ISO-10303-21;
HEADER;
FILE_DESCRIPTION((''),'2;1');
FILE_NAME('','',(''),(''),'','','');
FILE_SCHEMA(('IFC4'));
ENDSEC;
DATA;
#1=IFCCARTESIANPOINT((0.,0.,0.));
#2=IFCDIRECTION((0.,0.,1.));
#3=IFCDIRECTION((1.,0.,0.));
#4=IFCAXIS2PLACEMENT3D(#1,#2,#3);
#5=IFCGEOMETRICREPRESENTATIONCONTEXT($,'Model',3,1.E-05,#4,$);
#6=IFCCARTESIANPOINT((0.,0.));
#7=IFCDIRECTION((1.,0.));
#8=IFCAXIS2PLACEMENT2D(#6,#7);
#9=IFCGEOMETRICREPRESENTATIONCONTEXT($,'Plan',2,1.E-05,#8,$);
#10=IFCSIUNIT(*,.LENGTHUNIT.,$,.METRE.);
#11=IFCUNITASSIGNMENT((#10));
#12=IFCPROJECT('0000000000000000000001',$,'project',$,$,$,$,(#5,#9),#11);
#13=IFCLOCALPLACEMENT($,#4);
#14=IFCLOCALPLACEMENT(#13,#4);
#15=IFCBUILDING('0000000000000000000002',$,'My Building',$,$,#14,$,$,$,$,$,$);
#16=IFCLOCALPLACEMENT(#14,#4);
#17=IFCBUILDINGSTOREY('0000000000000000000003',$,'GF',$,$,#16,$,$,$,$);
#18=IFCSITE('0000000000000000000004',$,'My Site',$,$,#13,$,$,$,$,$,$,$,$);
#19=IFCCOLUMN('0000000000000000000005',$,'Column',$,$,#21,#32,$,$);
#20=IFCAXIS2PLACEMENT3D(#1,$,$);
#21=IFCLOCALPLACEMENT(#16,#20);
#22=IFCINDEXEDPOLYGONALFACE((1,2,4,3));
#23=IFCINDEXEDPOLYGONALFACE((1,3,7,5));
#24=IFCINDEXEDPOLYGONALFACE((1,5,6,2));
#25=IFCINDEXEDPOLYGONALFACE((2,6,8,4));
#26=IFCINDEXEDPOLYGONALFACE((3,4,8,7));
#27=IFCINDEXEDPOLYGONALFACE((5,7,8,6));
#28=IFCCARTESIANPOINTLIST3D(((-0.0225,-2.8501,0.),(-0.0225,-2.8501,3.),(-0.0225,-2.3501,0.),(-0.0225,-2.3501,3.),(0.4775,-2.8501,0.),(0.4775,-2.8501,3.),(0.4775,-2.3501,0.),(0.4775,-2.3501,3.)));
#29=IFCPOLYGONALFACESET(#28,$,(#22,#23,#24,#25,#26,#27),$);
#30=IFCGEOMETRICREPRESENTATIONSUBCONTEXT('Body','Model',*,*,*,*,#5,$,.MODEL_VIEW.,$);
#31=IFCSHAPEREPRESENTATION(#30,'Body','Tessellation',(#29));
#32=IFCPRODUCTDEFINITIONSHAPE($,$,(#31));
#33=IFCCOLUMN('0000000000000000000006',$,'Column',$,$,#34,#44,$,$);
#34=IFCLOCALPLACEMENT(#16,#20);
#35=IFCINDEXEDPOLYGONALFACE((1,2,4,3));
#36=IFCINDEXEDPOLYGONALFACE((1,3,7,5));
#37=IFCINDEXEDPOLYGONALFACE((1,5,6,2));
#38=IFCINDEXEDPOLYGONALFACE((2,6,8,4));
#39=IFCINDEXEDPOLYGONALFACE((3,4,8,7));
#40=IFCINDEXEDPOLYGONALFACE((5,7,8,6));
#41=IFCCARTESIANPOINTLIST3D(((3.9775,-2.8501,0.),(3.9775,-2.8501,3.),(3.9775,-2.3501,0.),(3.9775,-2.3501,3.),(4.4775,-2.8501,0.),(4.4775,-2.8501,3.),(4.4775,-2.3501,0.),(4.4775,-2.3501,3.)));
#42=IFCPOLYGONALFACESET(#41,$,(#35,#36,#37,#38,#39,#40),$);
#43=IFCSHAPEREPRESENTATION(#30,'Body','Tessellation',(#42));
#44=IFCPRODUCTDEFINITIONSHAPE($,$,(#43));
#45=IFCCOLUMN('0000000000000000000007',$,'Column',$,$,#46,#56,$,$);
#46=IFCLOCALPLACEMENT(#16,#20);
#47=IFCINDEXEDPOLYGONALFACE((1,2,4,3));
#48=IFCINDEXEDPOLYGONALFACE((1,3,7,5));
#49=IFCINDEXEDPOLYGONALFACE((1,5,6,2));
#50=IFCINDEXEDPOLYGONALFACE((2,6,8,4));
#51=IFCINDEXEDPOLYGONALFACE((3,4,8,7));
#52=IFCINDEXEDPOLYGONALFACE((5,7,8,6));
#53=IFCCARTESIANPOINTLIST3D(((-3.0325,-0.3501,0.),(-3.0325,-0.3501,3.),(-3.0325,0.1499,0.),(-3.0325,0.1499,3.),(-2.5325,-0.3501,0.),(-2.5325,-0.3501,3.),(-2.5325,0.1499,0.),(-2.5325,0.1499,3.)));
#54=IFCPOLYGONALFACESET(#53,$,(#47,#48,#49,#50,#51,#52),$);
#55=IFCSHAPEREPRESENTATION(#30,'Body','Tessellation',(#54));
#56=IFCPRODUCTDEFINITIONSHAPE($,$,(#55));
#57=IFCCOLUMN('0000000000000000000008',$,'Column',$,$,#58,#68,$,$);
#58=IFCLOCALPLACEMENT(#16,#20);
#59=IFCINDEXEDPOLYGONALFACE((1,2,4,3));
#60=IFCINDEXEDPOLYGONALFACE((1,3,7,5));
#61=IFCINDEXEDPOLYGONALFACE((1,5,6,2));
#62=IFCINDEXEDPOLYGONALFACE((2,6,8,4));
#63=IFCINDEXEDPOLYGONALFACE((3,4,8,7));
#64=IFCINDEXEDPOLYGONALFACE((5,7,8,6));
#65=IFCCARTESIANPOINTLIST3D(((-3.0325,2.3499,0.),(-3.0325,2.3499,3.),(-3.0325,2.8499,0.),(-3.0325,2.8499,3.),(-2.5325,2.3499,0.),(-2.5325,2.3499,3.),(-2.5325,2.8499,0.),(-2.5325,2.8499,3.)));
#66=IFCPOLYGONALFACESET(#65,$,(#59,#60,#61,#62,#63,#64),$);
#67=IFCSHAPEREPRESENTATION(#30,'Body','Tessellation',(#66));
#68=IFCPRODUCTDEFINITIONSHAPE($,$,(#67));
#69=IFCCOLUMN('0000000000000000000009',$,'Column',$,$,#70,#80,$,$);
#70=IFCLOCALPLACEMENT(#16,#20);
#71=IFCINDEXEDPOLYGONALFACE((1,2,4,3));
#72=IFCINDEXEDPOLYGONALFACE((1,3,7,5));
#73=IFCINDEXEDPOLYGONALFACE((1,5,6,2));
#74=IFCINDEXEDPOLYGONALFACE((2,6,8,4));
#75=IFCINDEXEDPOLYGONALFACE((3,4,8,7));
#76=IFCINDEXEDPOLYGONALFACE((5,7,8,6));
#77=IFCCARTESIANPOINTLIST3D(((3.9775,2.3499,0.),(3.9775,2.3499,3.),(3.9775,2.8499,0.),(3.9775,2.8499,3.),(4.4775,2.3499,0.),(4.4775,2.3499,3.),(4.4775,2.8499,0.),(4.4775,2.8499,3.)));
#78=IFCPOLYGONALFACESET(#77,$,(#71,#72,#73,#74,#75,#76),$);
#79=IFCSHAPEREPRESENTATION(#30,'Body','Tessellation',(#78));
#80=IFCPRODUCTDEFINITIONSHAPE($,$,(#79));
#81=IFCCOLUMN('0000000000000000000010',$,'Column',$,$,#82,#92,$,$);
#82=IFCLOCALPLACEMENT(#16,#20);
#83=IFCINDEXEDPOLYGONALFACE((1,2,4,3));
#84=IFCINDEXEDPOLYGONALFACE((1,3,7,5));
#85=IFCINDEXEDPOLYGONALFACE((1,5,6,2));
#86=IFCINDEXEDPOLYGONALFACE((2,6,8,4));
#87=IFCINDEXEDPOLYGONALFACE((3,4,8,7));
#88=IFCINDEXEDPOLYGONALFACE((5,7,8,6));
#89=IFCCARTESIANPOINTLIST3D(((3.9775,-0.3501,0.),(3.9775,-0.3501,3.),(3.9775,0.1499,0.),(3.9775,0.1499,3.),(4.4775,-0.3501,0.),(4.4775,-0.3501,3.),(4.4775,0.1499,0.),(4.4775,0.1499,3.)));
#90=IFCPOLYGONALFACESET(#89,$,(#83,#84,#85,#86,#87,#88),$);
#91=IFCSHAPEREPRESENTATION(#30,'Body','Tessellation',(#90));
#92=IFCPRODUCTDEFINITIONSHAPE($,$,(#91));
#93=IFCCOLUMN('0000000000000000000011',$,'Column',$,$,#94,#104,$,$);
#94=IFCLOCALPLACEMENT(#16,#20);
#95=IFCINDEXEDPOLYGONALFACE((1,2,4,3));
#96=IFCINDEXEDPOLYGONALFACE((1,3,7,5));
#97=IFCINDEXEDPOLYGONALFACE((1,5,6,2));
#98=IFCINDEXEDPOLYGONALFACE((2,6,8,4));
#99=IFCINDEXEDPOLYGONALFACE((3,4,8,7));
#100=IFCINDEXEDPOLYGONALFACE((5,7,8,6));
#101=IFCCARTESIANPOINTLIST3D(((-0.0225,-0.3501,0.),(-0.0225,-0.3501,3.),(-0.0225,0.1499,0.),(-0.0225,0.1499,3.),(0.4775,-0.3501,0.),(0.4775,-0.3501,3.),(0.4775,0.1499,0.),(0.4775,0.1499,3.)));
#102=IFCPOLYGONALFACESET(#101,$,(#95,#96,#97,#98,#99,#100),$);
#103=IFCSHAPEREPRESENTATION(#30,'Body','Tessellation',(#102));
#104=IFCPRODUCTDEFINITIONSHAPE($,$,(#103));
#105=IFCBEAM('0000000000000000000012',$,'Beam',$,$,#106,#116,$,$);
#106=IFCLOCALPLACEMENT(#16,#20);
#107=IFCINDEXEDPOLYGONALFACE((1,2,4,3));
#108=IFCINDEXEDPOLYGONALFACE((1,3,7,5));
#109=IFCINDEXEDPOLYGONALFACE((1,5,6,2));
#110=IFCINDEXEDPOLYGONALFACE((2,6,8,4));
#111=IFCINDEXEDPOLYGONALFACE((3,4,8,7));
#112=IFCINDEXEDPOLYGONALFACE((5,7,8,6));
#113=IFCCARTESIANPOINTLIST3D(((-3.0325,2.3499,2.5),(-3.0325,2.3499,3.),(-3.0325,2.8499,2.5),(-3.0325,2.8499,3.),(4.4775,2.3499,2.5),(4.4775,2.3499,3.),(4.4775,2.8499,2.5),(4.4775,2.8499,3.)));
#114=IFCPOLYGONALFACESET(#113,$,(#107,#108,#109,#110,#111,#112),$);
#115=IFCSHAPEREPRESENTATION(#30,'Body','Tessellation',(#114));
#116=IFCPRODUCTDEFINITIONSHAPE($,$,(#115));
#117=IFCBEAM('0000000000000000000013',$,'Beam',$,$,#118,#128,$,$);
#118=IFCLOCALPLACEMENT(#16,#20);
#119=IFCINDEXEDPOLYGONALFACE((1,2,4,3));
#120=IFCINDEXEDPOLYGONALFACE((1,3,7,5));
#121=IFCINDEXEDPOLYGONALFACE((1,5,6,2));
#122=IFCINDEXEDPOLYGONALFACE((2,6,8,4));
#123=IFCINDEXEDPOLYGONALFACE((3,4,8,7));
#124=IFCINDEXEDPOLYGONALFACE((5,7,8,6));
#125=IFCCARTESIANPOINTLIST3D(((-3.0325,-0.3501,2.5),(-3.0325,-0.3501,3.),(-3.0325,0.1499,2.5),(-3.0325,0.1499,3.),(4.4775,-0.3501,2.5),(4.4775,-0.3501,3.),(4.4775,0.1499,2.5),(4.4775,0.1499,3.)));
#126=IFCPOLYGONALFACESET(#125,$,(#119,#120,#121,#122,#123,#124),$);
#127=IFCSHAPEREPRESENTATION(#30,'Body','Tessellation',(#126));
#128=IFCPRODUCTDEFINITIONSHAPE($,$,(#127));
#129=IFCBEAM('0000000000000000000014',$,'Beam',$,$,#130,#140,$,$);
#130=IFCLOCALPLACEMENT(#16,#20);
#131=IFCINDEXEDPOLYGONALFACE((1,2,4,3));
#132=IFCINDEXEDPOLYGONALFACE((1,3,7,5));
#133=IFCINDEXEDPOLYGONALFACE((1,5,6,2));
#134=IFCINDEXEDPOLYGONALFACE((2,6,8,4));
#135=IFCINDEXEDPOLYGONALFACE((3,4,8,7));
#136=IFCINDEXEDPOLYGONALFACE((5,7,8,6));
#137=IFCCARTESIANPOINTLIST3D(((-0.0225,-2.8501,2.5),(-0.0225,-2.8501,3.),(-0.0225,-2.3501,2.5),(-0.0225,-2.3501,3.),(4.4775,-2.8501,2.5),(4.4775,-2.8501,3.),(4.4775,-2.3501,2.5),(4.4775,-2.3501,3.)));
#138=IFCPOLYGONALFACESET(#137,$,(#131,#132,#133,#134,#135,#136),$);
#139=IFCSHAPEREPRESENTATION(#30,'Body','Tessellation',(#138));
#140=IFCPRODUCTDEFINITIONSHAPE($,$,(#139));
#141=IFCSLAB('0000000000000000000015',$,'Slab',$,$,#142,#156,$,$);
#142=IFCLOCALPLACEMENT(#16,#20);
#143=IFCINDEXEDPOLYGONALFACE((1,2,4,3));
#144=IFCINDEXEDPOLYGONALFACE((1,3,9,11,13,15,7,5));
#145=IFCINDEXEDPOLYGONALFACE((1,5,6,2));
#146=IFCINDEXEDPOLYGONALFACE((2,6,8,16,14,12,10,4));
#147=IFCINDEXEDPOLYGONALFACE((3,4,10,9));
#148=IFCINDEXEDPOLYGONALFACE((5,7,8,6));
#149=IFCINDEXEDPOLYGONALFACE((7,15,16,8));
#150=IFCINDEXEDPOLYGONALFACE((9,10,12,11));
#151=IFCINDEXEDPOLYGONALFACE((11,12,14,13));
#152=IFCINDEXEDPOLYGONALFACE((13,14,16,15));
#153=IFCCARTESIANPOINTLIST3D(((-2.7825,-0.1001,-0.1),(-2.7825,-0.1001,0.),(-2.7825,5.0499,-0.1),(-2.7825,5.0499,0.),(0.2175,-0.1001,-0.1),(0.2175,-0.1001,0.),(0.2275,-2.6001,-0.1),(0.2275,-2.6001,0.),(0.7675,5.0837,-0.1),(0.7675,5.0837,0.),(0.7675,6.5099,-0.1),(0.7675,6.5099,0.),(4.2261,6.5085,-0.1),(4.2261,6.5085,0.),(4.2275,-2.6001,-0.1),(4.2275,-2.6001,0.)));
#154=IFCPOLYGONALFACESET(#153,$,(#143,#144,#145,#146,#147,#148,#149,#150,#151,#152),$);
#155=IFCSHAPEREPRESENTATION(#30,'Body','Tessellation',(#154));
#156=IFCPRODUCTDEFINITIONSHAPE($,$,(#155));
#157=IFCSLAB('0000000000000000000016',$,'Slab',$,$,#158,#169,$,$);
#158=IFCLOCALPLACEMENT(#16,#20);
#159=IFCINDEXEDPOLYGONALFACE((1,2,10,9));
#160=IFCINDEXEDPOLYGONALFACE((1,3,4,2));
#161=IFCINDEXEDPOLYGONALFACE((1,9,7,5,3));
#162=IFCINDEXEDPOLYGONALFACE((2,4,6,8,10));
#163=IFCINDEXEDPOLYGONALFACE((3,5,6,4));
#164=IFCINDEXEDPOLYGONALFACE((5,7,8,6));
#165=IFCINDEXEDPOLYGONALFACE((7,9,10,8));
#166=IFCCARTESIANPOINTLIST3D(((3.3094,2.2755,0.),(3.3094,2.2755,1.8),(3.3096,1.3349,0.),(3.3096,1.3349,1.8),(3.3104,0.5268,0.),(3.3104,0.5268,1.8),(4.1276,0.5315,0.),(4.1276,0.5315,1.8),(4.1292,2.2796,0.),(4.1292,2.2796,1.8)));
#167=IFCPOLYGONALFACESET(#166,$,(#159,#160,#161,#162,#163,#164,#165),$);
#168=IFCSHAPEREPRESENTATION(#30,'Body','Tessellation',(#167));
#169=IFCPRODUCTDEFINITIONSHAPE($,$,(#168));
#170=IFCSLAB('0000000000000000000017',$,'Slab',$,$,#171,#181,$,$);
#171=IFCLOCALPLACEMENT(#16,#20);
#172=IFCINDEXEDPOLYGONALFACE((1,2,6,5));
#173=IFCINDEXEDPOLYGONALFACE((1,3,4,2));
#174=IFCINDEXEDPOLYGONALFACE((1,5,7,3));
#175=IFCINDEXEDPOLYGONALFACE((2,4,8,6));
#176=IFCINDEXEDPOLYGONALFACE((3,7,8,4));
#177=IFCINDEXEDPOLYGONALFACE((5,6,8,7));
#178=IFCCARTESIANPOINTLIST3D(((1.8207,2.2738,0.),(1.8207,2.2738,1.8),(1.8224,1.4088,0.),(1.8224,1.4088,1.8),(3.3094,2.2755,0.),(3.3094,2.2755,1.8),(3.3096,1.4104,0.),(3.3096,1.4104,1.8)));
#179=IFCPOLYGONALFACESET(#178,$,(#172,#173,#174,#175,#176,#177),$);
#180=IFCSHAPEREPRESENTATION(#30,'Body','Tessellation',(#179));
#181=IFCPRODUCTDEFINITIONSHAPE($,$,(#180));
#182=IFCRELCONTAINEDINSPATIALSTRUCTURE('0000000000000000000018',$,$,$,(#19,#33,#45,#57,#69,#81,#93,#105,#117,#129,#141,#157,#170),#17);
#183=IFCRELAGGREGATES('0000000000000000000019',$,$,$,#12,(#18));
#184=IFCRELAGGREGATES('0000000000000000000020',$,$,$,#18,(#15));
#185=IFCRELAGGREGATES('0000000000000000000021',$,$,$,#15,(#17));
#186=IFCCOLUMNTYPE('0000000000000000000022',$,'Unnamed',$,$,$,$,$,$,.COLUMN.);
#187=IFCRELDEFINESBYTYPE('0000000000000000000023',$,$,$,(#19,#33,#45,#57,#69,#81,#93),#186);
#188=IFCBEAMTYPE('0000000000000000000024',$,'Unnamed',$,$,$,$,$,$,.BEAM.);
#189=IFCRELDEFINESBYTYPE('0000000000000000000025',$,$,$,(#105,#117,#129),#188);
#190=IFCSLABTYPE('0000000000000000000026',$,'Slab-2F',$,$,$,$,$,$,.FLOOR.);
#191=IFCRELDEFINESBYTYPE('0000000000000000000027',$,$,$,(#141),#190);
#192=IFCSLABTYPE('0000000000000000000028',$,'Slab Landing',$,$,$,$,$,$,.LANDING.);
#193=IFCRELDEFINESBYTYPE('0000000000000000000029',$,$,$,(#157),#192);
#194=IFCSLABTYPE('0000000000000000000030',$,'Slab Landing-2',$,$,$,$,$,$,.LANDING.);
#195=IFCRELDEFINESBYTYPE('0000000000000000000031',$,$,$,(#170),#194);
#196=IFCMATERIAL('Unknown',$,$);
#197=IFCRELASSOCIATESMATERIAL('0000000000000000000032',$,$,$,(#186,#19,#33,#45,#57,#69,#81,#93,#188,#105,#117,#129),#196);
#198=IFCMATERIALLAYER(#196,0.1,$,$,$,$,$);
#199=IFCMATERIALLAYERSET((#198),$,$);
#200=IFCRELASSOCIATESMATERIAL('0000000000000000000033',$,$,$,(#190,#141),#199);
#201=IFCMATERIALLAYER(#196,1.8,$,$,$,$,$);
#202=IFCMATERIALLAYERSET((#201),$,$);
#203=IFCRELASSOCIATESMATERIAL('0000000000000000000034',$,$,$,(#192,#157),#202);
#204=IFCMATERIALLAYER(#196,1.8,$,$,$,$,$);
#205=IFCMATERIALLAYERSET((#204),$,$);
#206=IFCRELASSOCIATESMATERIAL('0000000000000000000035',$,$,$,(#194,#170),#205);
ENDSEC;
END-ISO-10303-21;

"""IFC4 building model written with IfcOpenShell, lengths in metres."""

from ifc_helpers import new_model, si_unit, frame, origin_with_axes, origin_2d_with_axis, place, context, subcontext, project, spatial, indexed_curve, rectangle, outline, extrude, material, layer, layer_set, layer_usage, material_profile, profile_set, profile_usage, type_object, element, save


model = new_model("IFC4")

# Units and contexts
model_context = context("Model", 3, precision=1e-05, world=origin_with_axes())
plan_context = context("Plan", 2, precision=1e-05, world=origin_2d_with_axis())
body_context_1 = subcontext(model_context, "Body", "Model", "MODEL_VIEW")
ifc_project = project(units=[si_unit("LENGTHUNIT", "METRE")], contexts=[model_context, plan_context])

# Site, building, storey
site_placement = place(None, origin_with_axes())
site = spatial("IfcSite", under=ifc_project, at=site_placement, Name="My Site")
building_placement = place(site_placement, origin_with_axes())
building = spatial("IfcBuilding", under=site, at=building_placement, Name="My Building")
storey_placement = place(building_placement, origin_with_axes())
storey = spatial("IfcBuildingStorey", under=building, at=storey_placement, Name="GF")

# Columns
ifc_material = material(Name="Unknown")
ifc_material_profile_1 = material_profile(ifc_material, rectangle(XDim=0.5, YDim=0.5))
ifc_profile_set_1 = profile_set([ifc_material_profile_1])
ifc_profile_usage_1 = profile_usage(ifc_profile_set_1, cardinal=5)
column_type = type_object("IfcColumnType", Name="Unnamed", PredefinedType="COLUMN", material=ifc_profile_set_1)
column_1_placement = place(storey_placement, frame((0.2275, -2.6001, 0.0), z_axis=(0.0, 0.0, 1.0), x_axis=(1.0, 0.0, 0.0)))
element("IfcColumn", 1, at=column_1_placement, inside=storey, type_object=column_type, material=ifc_profile_usage_1, Name="Column", context=body_context_1, shape_type="SweptSolid", body=[
    extrude(rectangle(XDim=0.5, YDim=0.5), origin_with_axes(), (0.0, 0.0, 1.0), 3.0),
])
ifc_profile_usage_2 = profile_usage(ifc_profile_set_1, cardinal=5)
column_2_placement = place(storey_placement, frame((4.2275, -2.6001, 0.0), z_axis=(0.0, 0.0, 1.0), x_axis=(1.0, 0.0, 0.0)))
element("IfcColumn", 2, at=column_2_placement, inside=storey, type_object=column_type, material=ifc_profile_usage_2, Name="Column", context=body_context_1, shape_type="SweptSolid", body=[
    extrude(rectangle(XDim=0.5, YDim=0.5), origin_with_axes(), (0.0, 0.0, 1.0), 3.0),
])
ifc_profile_usage_3 = profile_usage(ifc_profile_set_1, cardinal=5)
column_3_placement = place(storey_placement, frame((-2.7825, -0.1001, 0.0), z_axis=(0.0, 0.0, 1.0), x_axis=(1.0, 0.0, 0.0)))
element("IfcColumn", 3, at=column_3_placement, inside=storey, type_object=column_type, material=ifc_profile_usage_3, Name="Column", context=body_context_1, shape_type="SweptSolid", body=[
    extrude(rectangle(XDim=0.5, YDim=0.5), origin_with_axes(), (0.0, 0.0, 1.0), 3.0),
])
ifc_profile_usage_4 = profile_usage(ifc_profile_set_1, cardinal=5)
column_4_placement = place(storey_placement, frame((-2.7825, 2.5999, 0.0), z_axis=(0.0, 0.0, 1.0), x_axis=(1.0, 0.0, 0.0)))
element("IfcColumn", 4, at=column_4_placement, inside=storey, type_object=column_type, material=ifc_profile_usage_4, Name="Column", context=body_context_1, shape_type="SweptSolid", body=[
    extrude(rectangle(XDim=0.5, YDim=0.5), origin_with_axes(), (0.0, 0.0, 1.0), 3.0),
])
ifc_profile_usage_5 = profile_usage(ifc_profile_set_1, cardinal=5)
column_5_placement = place(storey_placement, frame((4.2275, 2.5999, 0.0), z_axis=(0.0, 0.0, 1.0), x_axis=(1.0, 0.0, 0.0)))
element("IfcColumn", 5, at=column_5_placement, inside=storey, type_object=column_type, material=ifc_profile_usage_5, Name="Column", context=body_context_1, shape_type="SweptSolid", body=[
    extrude(rectangle(XDim=0.5, YDim=0.5), origin_with_axes(), (0.0, 0.0, 1.0), 3.0),
])
ifc_profile_usage_6 = profile_usage(ifc_profile_set_1, cardinal=5)
column_6_placement = place(storey_placement, frame((4.2275, -0.1001, 0.0), z_axis=(0.0, 0.0, 1.0), x_axis=(1.0, 0.0, 0.0)))
element("IfcColumn", 6, at=column_6_placement, inside=storey, type_object=column_type, material=ifc_profile_usage_6, Name="Column", context=body_context_1, shape_type="SweptSolid", body=[
    extrude(rectangle(XDim=0.5, YDim=0.5), origin_with_axes(), (0.0, 0.0, 1.0), 3.0),
])
ifc_profile_usage_7 = profile_usage(ifc_profile_set_1, cardinal=5)
column_7_placement = place(storey_placement, frame((0.2275, -0.1001, 0.0), z_axis=(0.0, 0.0, 1.0), x_axis=(1.0, 0.0, 0.0)))
element("IfcColumn", 7, at=column_7_placement, inside=storey, type_object=column_type, material=ifc_profile_usage_7, Name="Column", context=body_context_1, shape_type="SweptSolid", body=[
    extrude(rectangle(XDim=0.5, YDim=0.5), origin_with_axes(), (0.0, 0.0, 1.0), 3.0),
])

# Beams
ifc_material_profile_2 = material_profile(ifc_material, rectangle(XDim=0.5, YDim=0.5))
ifc_profile_set_2 = profile_set([ifc_material_profile_2])
ifc_profile_usage_8 = profile_usage(ifc_profile_set_2, cardinal=7)
beam_type = type_object("IfcBeamType", Name="Unnamed", PredefinedType="BEAM", material=ifc_profile_set_2)
beam_1_placement = place(storey_placement, frame((4.4775, 2.3499, 3.0), z_axis=(-1.0, 0.0, 0.0), x_axis=(0.0, -1.0, 0.0)))
element("IfcBeam", 8, at=beam_1_placement, inside=storey, type_object=beam_type, material=ifc_profile_usage_8, Name="Beam", context=body_context_1, shape_type="SweptSolid", body=[
    extrude(rectangle(XDim=0.5, YDim=0.5), frame((-0.25, -0.25, 0.0), z_axis=(0.0, 0.0, 1.0), x_axis=(1.0, 0.0, 0.0)), (0.0, 0.0, 1.0), 7.51),
])
ifc_profile_usage_9 = profile_usage(ifc_profile_set_2, cardinal=7)
beam_2_placement = place(storey_placement, frame((-3.0325, 0.1499, 3.0), z_axis=(1.0, 0.0, 0.0), x_axis=(0.0, 1.0, 0.0)))
element("IfcBeam", 9, at=beam_2_placement, inside=storey, type_object=beam_type, material=ifc_profile_usage_9, Name="Beam", context=body_context_1, shape_type="SweptSolid", body=[
    extrude(rectangle(XDim=0.5, YDim=0.5), frame((-0.25, -0.25, 0.0), z_axis=(0.0, 0.0, 1.0), x_axis=(1.0, 0.0, 0.0)), (0.0, 0.0, 1.0), 7.51),
])
ifc_profile_usage_10 = profile_usage(ifc_profile_set_2, cardinal=7)
beam_3_placement = place(storey_placement, frame((4.4775, -2.8501, 3.0), z_axis=(-1.0, -0.000001, 0.000001), x_axis=(0.000001, -1.0, 0.000001)))
element("IfcBeam", 10, at=beam_3_placement, inside=storey, type_object=beam_type, material=ifc_profile_usage_10, Name="Beam", context=body_context_1, shape_type="SweptSolid", body=[
    extrude(rectangle(XDim=0.5, YDim=0.5), frame((-0.25, -0.25, 0.0), z_axis=(0.0, 0.0, 1.0), x_axis=(1.0, 0.0, 0.0)), (0.0, 0.0, 1.0), 4.5),
])

# Slabs
ifc_layer_1 = layer(ifc_material, 0.1)
ifc_layer_set_1 = layer_set([ifc_layer_1])
ifc_layer_usage_1 = layer_usage(ifc_layer_set_1, "AXIS3", "POSITIVE", -0.1)
slab_type_1 = type_object("IfcSlabType", Name="Slab-2F", PredefinedType="FLOOR", material=ifc_layer_set_1)
slab_1_placement = place(storey_placement, frame((4.2275, -2.6001, 0.0), z_axis=(0.0, 0.0, 1.0), x_axis=(1.0, 0.0, 0.0)))
element("IfcSlab", 11, at=slab_1_placement, inside=storey, type_object=slab_type_1, material=ifc_layer_usage_1, Name="Slab", context=body_context_1, shape_type="SweptSolid", body=[
    extrude(outline(indexed_curve([(0.0, 0.0), (-0.0014, 9.1086), (-3.46, 9.11), (-3.46, 7.6838), (-7.01, 7.65), (-7.01, 2.5), (-4.01, 2.5), (-4.0, 0.0), (0.0, 0.0)])), frame((0.0, 0.0, -0.1), z_axis=(0.0, 0.0, 1.0), x_axis=(1.0, 0.0, 0.0)), (0.0, 0.0, 1.0), 0.1),
])
ifc_layer_2 = layer(ifc_material, 1.8)
ifc_layer_set_2 = layer_set([ifc_layer_2])
ifc_layer_usage_2 = layer_usage(ifc_layer_set_2, "AXIS3", "POSITIVE", -0.1)
slab_type_2 = type_object("IfcSlabType", Name="Slab Landing", PredefinedType="LANDING", material=ifc_layer_set_2)
slab_2_placement = place(storey_placement, frame((3.3096, 1.3349, 0.1), z_axis=(0.0, 0.0, 1.0), x_axis=(1.0, 0.0, 0.0)))
element("IfcSlab", 12, at=slab_2_placement, inside=storey, type_object=slab_type_2, material=ifc_layer_usage_2, Name="Slab", context=body_context_1, shape_type="SweptSolid", body=[
    extrude(outline(indexed_curve([(0.0, 0.0), (0.0008, -0.8081), (0.818, -0.8034), (0.8196, 0.9447), (-0.0002, 0.9407), (0.0, 0.0)])), frame((0.0, 0.0, -0.1), z_axis=(0.0, 0.0, 1.0), x_axis=(1.0, 0.0, 0.0)), (0.0, 0.0, 1.0), 1.8),
])
ifc_layer_3 = layer(ifc_material, 1.8)
ifc_layer_set_3 = layer_set([ifc_layer_3])
ifc_layer_usage_3 = layer_usage(ifc_layer_set_3, "AXIS3", "POSITIVE", -1.8)
slab_type_3 = type_object("IfcSlabType", Name="Slab Landing-2", PredefinedType="LANDING", material=ifc_layer_set_3)
slab_3_placement = place(storey_placement, frame((3.3094, 2.2755, 1.8), z_axis=(0.0, 0.0, 1.0), x_axis=(1.0, 0.0, 0.0)))
element("IfcSlab", 13, at=slab_3_placement, inside=storey, type_object=slab_type_3, material=ifc_layer_usage_3, Name="Slab", context=body_context_1, shape_type="SweptSolid", body=[
    extrude(outline(indexed_curve([(0.0, 0.0), (0.0002, -0.8651), (-1.487, -0.8667), (-1.4887, -0.0017), (0.0, 0.0)])), frame((0.0, 0.0, -1.8), z_axis=(0.0, 0.0, 1.0), x_axis=(1.0, 0.0, 0.0)), (0.0, 0.0, 1.0), 1.8),
])

save(model, "model.ifc")
